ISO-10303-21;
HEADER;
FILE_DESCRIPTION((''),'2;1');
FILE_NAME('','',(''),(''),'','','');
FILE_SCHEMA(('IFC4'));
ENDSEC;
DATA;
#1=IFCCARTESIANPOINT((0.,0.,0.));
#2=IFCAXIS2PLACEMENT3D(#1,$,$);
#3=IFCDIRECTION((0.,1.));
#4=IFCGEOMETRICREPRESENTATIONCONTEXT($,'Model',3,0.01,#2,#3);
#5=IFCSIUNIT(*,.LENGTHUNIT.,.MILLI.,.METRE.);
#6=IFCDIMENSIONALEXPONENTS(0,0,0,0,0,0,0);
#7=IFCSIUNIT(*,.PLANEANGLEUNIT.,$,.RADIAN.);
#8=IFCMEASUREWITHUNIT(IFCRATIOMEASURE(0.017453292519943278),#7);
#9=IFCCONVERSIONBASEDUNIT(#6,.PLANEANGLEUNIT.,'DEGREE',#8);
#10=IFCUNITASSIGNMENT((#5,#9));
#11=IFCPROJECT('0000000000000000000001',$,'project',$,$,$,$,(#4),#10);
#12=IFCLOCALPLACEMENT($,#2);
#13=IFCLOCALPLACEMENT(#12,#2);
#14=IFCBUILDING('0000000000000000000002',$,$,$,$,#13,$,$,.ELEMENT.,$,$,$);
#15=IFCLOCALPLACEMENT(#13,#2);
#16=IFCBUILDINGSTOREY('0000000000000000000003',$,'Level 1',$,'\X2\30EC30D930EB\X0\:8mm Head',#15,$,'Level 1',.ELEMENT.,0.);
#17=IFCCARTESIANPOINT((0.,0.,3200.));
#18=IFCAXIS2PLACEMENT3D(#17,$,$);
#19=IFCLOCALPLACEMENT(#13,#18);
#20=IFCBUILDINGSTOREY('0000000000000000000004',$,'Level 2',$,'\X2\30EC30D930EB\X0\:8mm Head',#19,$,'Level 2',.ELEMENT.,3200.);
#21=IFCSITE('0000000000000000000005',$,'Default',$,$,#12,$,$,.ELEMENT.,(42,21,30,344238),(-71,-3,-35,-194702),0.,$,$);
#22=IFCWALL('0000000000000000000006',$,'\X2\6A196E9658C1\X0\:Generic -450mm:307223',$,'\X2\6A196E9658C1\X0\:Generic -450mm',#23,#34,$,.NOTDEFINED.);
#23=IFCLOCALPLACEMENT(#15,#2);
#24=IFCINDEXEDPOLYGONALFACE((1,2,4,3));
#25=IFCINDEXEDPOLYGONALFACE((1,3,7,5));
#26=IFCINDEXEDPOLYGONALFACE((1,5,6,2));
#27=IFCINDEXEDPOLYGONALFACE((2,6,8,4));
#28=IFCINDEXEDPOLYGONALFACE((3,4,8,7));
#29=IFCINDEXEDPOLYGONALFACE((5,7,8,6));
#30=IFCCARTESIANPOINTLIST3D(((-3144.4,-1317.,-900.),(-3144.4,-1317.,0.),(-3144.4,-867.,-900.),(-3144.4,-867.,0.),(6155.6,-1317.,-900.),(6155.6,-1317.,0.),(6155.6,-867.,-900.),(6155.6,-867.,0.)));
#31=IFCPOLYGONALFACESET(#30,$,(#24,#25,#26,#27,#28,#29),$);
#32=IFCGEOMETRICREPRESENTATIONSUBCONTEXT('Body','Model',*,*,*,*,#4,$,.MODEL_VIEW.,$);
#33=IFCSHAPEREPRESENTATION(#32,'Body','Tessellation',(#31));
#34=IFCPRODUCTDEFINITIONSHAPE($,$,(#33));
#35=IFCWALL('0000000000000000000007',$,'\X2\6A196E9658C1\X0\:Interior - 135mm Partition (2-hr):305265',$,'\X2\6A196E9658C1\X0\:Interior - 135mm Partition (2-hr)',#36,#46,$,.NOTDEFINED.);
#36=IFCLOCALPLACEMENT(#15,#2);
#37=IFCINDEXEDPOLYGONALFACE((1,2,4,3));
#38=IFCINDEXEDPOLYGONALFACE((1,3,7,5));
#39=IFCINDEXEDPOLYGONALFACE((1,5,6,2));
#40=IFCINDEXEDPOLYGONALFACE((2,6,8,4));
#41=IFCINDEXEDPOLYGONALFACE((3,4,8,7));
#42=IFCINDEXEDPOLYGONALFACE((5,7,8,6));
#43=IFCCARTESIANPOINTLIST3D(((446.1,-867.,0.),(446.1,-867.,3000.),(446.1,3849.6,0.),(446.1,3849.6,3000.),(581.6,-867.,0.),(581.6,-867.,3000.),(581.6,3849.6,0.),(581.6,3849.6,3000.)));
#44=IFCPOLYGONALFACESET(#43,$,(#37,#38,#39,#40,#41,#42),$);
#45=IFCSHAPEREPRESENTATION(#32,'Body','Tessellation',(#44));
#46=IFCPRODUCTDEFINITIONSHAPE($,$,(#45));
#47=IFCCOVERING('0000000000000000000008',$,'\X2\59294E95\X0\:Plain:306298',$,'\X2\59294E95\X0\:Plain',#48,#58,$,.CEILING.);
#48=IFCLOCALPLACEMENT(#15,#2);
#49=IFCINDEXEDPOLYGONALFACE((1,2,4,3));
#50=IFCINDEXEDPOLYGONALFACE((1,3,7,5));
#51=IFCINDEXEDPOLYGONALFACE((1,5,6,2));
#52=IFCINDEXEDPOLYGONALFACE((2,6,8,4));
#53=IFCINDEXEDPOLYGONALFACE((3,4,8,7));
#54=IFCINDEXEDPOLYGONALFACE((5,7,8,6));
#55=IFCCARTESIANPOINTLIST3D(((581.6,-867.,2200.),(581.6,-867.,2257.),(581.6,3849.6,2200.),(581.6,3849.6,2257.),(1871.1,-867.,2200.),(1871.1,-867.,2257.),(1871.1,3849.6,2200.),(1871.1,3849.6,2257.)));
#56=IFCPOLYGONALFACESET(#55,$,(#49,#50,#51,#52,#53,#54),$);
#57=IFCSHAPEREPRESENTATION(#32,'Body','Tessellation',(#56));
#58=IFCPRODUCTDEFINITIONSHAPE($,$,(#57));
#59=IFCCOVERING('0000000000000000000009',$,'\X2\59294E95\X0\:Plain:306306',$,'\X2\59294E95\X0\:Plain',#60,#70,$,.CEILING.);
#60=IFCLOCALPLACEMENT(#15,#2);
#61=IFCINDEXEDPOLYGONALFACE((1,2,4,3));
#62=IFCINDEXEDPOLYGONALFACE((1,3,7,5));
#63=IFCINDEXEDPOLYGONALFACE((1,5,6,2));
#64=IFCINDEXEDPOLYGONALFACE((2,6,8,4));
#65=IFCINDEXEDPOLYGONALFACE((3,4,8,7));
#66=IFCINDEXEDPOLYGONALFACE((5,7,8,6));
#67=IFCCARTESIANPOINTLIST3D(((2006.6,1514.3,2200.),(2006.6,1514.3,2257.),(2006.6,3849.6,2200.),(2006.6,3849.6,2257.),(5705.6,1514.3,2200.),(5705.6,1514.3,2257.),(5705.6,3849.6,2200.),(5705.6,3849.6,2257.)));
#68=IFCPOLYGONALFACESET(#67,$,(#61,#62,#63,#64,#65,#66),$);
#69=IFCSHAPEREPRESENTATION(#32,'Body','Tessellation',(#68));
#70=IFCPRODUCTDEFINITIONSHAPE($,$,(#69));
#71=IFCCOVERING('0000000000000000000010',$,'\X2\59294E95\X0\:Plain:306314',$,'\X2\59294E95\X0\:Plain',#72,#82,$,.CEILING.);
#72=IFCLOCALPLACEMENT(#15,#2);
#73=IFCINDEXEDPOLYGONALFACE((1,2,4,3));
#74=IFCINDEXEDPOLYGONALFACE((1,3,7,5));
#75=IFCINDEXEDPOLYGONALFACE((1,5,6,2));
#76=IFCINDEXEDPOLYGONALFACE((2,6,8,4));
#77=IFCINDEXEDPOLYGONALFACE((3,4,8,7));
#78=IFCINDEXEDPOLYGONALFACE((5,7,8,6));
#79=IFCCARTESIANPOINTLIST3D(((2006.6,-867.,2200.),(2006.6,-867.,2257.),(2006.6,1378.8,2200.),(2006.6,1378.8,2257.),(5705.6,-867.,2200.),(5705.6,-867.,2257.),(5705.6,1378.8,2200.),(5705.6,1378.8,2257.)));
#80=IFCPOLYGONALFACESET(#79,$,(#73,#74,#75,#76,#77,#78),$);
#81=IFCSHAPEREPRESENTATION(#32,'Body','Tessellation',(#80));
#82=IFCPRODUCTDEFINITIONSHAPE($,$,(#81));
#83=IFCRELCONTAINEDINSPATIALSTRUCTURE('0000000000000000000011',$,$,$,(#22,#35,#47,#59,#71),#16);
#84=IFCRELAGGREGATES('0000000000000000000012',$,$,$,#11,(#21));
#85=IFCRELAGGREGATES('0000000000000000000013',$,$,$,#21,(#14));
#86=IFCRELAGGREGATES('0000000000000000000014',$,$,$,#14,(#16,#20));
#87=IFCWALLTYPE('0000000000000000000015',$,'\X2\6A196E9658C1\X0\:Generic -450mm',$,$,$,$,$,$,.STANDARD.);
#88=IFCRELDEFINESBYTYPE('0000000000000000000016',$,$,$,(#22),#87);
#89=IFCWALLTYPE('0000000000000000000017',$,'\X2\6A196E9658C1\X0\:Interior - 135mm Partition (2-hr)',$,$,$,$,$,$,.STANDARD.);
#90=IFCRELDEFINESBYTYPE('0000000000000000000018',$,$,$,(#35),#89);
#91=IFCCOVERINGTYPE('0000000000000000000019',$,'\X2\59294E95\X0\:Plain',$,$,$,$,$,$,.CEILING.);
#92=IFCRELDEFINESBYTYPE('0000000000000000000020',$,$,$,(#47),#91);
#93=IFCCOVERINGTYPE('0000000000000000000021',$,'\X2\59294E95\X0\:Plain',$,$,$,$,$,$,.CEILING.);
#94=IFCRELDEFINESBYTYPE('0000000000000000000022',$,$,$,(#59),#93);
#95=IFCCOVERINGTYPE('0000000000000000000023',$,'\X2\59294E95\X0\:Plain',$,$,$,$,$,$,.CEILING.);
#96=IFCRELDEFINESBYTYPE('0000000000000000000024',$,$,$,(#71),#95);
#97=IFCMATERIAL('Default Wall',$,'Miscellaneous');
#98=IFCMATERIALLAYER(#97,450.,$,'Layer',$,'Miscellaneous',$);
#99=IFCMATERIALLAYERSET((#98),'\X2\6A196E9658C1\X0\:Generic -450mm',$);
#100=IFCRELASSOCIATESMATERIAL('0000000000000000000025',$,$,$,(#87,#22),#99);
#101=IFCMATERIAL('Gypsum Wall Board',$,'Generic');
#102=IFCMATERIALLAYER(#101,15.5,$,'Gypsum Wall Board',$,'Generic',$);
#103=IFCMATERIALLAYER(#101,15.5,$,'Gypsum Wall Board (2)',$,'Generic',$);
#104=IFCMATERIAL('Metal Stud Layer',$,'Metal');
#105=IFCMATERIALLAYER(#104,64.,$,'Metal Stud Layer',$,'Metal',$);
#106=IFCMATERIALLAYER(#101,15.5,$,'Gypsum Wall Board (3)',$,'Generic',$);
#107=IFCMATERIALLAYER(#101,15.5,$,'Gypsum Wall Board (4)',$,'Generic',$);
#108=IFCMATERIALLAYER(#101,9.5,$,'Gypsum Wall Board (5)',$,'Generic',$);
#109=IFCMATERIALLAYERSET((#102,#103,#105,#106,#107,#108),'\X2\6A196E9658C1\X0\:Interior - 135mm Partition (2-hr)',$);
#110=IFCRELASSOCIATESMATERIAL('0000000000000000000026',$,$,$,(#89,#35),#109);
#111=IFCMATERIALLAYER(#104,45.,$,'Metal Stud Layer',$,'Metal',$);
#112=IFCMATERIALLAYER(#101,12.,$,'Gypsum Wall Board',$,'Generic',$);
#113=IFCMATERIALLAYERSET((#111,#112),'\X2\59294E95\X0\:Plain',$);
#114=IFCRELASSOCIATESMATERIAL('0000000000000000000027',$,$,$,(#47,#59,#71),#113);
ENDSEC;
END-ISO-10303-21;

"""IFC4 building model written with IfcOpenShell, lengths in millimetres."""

from ifc_helpers import new_model, entity, si_unit, converted_unit, direction, frame, frame_2d, origin, place, context, subcontext, project, spatial, polyline, rectangle, extrude, clip, bounded_halfspace, material, layer, layer_set, layer_usage, type_object, element, save


model = new_model("IFC4")

# Units and contexts
model_context = context("Model", 3, precision=0.01, world=origin(), true_north=direction((0.0, 1.0)))
body_context = subcontext(model_context, "Body", "Model", "MODEL_VIEW")
ifc_project = project(units=[si_unit("LENGTHUNIT", "METRE", prefix="MILLI"), converted_unit("PLANEANGLEUNIT", "DEGREE", entity("IfcRatioMeasure", 0.017453292519943278), si_unit("PLANEANGLEUNIT", "RADIAN"), dimensions=[0, 0, 0, 0, 0, 0, 0])], contexts=[model_context])

# Site, building, storey
site_placement = place(None, origin())
site = spatial("IfcSite", under=ifc_project, at=site_placement, Name="Default", CompositionType="ELEMENT", RefLatitude=(42, 21, 30, 344238), RefLongitude=(-71, -3, -35, -194702), RefElevation=0.0)
building_placement = place(site_placement, origin())
building = spatial("IfcBuilding", under=site, at=building_placement, CompositionType="ELEMENT")
storey_1_placement = place(building_placement, origin())
storey_1 = spatial("IfcBuildingStorey", under=building, at=storey_1_placement, Name="Level 1", ObjectType="レベル:8mm Head", LongName="Level 1", CompositionType="ELEMENT", Elevation=0.0)

# Shared definitions
ifc_material_1 = material(Name="Default Wall", Category="Miscellaneous")
ifc_layer_1 = layer(ifc_material_1, 450.0, Name="Layer", Category="Miscellaneous")
ifc_layer_set_1 = layer_set([ifc_layer_1], Name="標準壁:Generic -450mm")
wall_type_1 = type_object("IfcWallType", Name="標準壁:Generic -450mm", PredefinedType="STANDARD", material=ifc_layer_set_1)

# Shared definitions
storey_2_placement = place(building_placement, frame((0.0, 0.0, 3200.0)))
storey_2 = spatial("IfcBuildingStorey", under=building, at=storey_2_placement, Name="Level 2", ObjectType="レベル:8mm Head", LongName="Level 2", CompositionType="ELEMENT", Elevation=3200.0)

# Walls
ifc_layer_usage_1 = layer_usage(ifc_layer_set_1, "AXIS2", "NEGATIVE", 225.0)
wall_1_placement = place(storey_1_placement, frame((6155.6, -1092.0, -900.0), z_axis=(0.0, 0.0, 1.0), x_axis=(-1.0, 0.0, 0.0)))
element("IfcWall", 1, at=wall_1_placement, inside=storey_1, type_object=wall_type_1, material=ifc_layer_usage_1, Name="標準壁:Generic -450mm:307223", ObjectType="標準壁:Generic -450mm", PredefinedType="NOTDEFINED", context=body_context, shape_type="SweptSolid", body=[
    extrude(rectangle(XDim=9300.0, YDim=450.0, at=frame_2d((4650.0, 0.0), x_axis=(-1.0, 0.0))), origin(), (0.0, 0.0, 1.0), 900.0),
])
ifc_material_2 = material(Name="Gypsum Wall Board", Category="Generic")
ifc_layer_2 = layer(ifc_material_2, 15.5, Name="Gypsum Wall Board", Category="Generic")
ifc_layer_3 = layer(ifc_material_2, 15.5, Name="Gypsum Wall Board (2)", Category="Generic")
ifc_material_3 = material(Name="Metal Stud Layer", Category="Metal")
ifc_layer_4 = layer(ifc_material_3, 64.0, Name="Metal Stud Layer", Category="Metal")
ifc_layer_5 = layer(ifc_material_2, 15.5, Name="Gypsum Wall Board (3)", Category="Generic")
ifc_layer_6 = layer(ifc_material_2, 15.5, Name="Gypsum Wall Board (4)", Category="Generic")
ifc_layer_7 = layer(ifc_material_2, 9.5, Name="Gypsum Wall Board (5)", Category="Generic")
ifc_layer_set_2 = layer_set([ifc_layer_2, ifc_layer_3, ifc_layer_4, ifc_layer_5, ifc_layer_6, ifc_layer_7], Name="標準壁:Interior - 135mm Partition (2-hr)")
ifc_layer_usage_2 = layer_usage(ifc_layer_set_2, "AXIS2", "NEGATIVE", 67.8)
wall_type_2 = type_object("IfcWallType", Name="標準壁:Interior - 135mm Partition (2-hr)", PredefinedType="STANDARD", material=ifc_layer_set_2)
wall_2_placement = place(storey_1_placement, frame((513.9, 3849.6, 0.0), z_axis=(0.0, 0.0, 1.0), x_axis=(0.0, -1.0, 0.0)))
element("IfcWall", 2, at=wall_2_placement, inside=storey_1, type_object=wall_type_2, material=ifc_layer_usage_2, Name="標準壁:Interior - 135mm Partition (2-hr):305265", ObjectType="標準壁:Interior - 135mm Partition (2-hr)", PredefinedType="NOTDEFINED", context=body_context, shape_type="Clipping", body=[
    clip(extrude(rectangle(XDim=4716.6, YDim=135.5, at=frame_2d((2358.3, 0.0), x_axis=(-1.0, 0.0))), origin(), (0.0, 0.0, 1.0), 3000.0), bounded_halfspace(frame((0.0, -67.7, 3000.0), z_axis=(0.0, 0.0, -1.0), x_axis=(0.0, 1.0, 0.0)), True, frame((0.0, -67.7, 3000.0)), polyline([(0.0, 0.0), (4716.6, 0.0), (4716.6, 135.5), (0.0, 135.5), (0.0, 0.0)]))),
])

# Coverings
ifc_layer_8 = layer(ifc_material_3, 45.0, Name="Metal Stud Layer", Category="Metal")
ifc_layer_9 = layer(ifc_material_2, 12.0, Name="Gypsum Wall Board", Category="Generic")
ifc_layer_set_3 = layer_set([ifc_layer_8, ifc_layer_9], Name="天井:Plain")
ifc_layer_usage_3 = layer_usage(ifc_layer_set_3, "AXIS3", "POSITIVE", 0.0)
covering_type_1 = type_object("IfcCoveringType", Name="天井:Plain", PredefinedType="CEILING")
covering_1_placement = place(storey_1_placement, frame((581.6, -867.0, 2200.0)))
element("IfcCovering", 3, at=covering_1_placement, inside=storey_1, type_object=covering_type_1, material=ifc_layer_usage_3, Name="天井:Plain:306298", ObjectType="天井:Plain", PredefinedType="CEILING", context=body_context, shape_type="SweptSolid", body=[
    extrude(rectangle(XDim=4716.6, YDim=1289.5, at=frame_2d((0.0, 0.0), x_axis=(1.0, 0.0))), frame((644.8, 2358.3, 0.0), z_axis=(0.0, 0.0, 1.0), x_axis=(0.0, 1.0, 0.0)), (0.0, 0.0, 1.0), 57.0),
])
ifc_layer_usage_4 = layer_usage(ifc_layer_set_3, "AXIS3", "POSITIVE", 0.0)
covering_type_2 = type_object("IfcCoveringType", Name="天井:Plain", PredefinedType="CEILING")
covering_2_placement = place(storey_1_placement, frame((2006.6, 1514.3, 2200.0)))
element("IfcCovering", 4, at=covering_2_placement, inside=storey_1, type_object=covering_type_2, material=ifc_layer_usage_4, Name="天井:Plain:306306", ObjectType="天井:Plain", PredefinedType="CEILING", context=body_context, shape_type="SweptSolid", body=[
    extrude(rectangle(XDim=3698.9, YDim=2335.3, at=frame_2d((0.0, 0.0), x_axis=(1.0, 0.0))), frame((1849.5, 1167.6, 0.0), z_axis=(0.0, 0.0, 1.0), x_axis=(-1.0, 0.0, 0.0)), (0.0, 0.0, 1.0), 57.0),
])
ifc_layer_usage_5 = layer_usage(ifc_layer_set_3, "AXIS3", "POSITIVE", 0.0)
covering_type_3 = type_object("IfcCoveringType", Name="天井:Plain", PredefinedType="CEILING")
covering_3_placement = place(storey_1_placement, frame((2006.6, -867.0, 2200.0)))
element("IfcCovering", 5, at=covering_3_placement, inside=storey_1, type_object=covering_type_3, material=ifc_layer_usage_5, Name="天井:Plain:306314", ObjectType="天井:Plain", PredefinedType="CEILING", context=body_context, shape_type="SweptSolid", body=[
    extrude(rectangle(XDim=2245.8, YDim=3698.9, at=frame_2d((0.0, 0.0), x_axis=(1.0, 0.0))), frame((1849.5, 1122.9, 0.0), z_axis=(0.0, 0.0, 1.0), x_axis=(0.0, 1.0, 0.0)), (0.0, 0.0, 1.0), 57.0),
])

save(model, "model.ifc")
